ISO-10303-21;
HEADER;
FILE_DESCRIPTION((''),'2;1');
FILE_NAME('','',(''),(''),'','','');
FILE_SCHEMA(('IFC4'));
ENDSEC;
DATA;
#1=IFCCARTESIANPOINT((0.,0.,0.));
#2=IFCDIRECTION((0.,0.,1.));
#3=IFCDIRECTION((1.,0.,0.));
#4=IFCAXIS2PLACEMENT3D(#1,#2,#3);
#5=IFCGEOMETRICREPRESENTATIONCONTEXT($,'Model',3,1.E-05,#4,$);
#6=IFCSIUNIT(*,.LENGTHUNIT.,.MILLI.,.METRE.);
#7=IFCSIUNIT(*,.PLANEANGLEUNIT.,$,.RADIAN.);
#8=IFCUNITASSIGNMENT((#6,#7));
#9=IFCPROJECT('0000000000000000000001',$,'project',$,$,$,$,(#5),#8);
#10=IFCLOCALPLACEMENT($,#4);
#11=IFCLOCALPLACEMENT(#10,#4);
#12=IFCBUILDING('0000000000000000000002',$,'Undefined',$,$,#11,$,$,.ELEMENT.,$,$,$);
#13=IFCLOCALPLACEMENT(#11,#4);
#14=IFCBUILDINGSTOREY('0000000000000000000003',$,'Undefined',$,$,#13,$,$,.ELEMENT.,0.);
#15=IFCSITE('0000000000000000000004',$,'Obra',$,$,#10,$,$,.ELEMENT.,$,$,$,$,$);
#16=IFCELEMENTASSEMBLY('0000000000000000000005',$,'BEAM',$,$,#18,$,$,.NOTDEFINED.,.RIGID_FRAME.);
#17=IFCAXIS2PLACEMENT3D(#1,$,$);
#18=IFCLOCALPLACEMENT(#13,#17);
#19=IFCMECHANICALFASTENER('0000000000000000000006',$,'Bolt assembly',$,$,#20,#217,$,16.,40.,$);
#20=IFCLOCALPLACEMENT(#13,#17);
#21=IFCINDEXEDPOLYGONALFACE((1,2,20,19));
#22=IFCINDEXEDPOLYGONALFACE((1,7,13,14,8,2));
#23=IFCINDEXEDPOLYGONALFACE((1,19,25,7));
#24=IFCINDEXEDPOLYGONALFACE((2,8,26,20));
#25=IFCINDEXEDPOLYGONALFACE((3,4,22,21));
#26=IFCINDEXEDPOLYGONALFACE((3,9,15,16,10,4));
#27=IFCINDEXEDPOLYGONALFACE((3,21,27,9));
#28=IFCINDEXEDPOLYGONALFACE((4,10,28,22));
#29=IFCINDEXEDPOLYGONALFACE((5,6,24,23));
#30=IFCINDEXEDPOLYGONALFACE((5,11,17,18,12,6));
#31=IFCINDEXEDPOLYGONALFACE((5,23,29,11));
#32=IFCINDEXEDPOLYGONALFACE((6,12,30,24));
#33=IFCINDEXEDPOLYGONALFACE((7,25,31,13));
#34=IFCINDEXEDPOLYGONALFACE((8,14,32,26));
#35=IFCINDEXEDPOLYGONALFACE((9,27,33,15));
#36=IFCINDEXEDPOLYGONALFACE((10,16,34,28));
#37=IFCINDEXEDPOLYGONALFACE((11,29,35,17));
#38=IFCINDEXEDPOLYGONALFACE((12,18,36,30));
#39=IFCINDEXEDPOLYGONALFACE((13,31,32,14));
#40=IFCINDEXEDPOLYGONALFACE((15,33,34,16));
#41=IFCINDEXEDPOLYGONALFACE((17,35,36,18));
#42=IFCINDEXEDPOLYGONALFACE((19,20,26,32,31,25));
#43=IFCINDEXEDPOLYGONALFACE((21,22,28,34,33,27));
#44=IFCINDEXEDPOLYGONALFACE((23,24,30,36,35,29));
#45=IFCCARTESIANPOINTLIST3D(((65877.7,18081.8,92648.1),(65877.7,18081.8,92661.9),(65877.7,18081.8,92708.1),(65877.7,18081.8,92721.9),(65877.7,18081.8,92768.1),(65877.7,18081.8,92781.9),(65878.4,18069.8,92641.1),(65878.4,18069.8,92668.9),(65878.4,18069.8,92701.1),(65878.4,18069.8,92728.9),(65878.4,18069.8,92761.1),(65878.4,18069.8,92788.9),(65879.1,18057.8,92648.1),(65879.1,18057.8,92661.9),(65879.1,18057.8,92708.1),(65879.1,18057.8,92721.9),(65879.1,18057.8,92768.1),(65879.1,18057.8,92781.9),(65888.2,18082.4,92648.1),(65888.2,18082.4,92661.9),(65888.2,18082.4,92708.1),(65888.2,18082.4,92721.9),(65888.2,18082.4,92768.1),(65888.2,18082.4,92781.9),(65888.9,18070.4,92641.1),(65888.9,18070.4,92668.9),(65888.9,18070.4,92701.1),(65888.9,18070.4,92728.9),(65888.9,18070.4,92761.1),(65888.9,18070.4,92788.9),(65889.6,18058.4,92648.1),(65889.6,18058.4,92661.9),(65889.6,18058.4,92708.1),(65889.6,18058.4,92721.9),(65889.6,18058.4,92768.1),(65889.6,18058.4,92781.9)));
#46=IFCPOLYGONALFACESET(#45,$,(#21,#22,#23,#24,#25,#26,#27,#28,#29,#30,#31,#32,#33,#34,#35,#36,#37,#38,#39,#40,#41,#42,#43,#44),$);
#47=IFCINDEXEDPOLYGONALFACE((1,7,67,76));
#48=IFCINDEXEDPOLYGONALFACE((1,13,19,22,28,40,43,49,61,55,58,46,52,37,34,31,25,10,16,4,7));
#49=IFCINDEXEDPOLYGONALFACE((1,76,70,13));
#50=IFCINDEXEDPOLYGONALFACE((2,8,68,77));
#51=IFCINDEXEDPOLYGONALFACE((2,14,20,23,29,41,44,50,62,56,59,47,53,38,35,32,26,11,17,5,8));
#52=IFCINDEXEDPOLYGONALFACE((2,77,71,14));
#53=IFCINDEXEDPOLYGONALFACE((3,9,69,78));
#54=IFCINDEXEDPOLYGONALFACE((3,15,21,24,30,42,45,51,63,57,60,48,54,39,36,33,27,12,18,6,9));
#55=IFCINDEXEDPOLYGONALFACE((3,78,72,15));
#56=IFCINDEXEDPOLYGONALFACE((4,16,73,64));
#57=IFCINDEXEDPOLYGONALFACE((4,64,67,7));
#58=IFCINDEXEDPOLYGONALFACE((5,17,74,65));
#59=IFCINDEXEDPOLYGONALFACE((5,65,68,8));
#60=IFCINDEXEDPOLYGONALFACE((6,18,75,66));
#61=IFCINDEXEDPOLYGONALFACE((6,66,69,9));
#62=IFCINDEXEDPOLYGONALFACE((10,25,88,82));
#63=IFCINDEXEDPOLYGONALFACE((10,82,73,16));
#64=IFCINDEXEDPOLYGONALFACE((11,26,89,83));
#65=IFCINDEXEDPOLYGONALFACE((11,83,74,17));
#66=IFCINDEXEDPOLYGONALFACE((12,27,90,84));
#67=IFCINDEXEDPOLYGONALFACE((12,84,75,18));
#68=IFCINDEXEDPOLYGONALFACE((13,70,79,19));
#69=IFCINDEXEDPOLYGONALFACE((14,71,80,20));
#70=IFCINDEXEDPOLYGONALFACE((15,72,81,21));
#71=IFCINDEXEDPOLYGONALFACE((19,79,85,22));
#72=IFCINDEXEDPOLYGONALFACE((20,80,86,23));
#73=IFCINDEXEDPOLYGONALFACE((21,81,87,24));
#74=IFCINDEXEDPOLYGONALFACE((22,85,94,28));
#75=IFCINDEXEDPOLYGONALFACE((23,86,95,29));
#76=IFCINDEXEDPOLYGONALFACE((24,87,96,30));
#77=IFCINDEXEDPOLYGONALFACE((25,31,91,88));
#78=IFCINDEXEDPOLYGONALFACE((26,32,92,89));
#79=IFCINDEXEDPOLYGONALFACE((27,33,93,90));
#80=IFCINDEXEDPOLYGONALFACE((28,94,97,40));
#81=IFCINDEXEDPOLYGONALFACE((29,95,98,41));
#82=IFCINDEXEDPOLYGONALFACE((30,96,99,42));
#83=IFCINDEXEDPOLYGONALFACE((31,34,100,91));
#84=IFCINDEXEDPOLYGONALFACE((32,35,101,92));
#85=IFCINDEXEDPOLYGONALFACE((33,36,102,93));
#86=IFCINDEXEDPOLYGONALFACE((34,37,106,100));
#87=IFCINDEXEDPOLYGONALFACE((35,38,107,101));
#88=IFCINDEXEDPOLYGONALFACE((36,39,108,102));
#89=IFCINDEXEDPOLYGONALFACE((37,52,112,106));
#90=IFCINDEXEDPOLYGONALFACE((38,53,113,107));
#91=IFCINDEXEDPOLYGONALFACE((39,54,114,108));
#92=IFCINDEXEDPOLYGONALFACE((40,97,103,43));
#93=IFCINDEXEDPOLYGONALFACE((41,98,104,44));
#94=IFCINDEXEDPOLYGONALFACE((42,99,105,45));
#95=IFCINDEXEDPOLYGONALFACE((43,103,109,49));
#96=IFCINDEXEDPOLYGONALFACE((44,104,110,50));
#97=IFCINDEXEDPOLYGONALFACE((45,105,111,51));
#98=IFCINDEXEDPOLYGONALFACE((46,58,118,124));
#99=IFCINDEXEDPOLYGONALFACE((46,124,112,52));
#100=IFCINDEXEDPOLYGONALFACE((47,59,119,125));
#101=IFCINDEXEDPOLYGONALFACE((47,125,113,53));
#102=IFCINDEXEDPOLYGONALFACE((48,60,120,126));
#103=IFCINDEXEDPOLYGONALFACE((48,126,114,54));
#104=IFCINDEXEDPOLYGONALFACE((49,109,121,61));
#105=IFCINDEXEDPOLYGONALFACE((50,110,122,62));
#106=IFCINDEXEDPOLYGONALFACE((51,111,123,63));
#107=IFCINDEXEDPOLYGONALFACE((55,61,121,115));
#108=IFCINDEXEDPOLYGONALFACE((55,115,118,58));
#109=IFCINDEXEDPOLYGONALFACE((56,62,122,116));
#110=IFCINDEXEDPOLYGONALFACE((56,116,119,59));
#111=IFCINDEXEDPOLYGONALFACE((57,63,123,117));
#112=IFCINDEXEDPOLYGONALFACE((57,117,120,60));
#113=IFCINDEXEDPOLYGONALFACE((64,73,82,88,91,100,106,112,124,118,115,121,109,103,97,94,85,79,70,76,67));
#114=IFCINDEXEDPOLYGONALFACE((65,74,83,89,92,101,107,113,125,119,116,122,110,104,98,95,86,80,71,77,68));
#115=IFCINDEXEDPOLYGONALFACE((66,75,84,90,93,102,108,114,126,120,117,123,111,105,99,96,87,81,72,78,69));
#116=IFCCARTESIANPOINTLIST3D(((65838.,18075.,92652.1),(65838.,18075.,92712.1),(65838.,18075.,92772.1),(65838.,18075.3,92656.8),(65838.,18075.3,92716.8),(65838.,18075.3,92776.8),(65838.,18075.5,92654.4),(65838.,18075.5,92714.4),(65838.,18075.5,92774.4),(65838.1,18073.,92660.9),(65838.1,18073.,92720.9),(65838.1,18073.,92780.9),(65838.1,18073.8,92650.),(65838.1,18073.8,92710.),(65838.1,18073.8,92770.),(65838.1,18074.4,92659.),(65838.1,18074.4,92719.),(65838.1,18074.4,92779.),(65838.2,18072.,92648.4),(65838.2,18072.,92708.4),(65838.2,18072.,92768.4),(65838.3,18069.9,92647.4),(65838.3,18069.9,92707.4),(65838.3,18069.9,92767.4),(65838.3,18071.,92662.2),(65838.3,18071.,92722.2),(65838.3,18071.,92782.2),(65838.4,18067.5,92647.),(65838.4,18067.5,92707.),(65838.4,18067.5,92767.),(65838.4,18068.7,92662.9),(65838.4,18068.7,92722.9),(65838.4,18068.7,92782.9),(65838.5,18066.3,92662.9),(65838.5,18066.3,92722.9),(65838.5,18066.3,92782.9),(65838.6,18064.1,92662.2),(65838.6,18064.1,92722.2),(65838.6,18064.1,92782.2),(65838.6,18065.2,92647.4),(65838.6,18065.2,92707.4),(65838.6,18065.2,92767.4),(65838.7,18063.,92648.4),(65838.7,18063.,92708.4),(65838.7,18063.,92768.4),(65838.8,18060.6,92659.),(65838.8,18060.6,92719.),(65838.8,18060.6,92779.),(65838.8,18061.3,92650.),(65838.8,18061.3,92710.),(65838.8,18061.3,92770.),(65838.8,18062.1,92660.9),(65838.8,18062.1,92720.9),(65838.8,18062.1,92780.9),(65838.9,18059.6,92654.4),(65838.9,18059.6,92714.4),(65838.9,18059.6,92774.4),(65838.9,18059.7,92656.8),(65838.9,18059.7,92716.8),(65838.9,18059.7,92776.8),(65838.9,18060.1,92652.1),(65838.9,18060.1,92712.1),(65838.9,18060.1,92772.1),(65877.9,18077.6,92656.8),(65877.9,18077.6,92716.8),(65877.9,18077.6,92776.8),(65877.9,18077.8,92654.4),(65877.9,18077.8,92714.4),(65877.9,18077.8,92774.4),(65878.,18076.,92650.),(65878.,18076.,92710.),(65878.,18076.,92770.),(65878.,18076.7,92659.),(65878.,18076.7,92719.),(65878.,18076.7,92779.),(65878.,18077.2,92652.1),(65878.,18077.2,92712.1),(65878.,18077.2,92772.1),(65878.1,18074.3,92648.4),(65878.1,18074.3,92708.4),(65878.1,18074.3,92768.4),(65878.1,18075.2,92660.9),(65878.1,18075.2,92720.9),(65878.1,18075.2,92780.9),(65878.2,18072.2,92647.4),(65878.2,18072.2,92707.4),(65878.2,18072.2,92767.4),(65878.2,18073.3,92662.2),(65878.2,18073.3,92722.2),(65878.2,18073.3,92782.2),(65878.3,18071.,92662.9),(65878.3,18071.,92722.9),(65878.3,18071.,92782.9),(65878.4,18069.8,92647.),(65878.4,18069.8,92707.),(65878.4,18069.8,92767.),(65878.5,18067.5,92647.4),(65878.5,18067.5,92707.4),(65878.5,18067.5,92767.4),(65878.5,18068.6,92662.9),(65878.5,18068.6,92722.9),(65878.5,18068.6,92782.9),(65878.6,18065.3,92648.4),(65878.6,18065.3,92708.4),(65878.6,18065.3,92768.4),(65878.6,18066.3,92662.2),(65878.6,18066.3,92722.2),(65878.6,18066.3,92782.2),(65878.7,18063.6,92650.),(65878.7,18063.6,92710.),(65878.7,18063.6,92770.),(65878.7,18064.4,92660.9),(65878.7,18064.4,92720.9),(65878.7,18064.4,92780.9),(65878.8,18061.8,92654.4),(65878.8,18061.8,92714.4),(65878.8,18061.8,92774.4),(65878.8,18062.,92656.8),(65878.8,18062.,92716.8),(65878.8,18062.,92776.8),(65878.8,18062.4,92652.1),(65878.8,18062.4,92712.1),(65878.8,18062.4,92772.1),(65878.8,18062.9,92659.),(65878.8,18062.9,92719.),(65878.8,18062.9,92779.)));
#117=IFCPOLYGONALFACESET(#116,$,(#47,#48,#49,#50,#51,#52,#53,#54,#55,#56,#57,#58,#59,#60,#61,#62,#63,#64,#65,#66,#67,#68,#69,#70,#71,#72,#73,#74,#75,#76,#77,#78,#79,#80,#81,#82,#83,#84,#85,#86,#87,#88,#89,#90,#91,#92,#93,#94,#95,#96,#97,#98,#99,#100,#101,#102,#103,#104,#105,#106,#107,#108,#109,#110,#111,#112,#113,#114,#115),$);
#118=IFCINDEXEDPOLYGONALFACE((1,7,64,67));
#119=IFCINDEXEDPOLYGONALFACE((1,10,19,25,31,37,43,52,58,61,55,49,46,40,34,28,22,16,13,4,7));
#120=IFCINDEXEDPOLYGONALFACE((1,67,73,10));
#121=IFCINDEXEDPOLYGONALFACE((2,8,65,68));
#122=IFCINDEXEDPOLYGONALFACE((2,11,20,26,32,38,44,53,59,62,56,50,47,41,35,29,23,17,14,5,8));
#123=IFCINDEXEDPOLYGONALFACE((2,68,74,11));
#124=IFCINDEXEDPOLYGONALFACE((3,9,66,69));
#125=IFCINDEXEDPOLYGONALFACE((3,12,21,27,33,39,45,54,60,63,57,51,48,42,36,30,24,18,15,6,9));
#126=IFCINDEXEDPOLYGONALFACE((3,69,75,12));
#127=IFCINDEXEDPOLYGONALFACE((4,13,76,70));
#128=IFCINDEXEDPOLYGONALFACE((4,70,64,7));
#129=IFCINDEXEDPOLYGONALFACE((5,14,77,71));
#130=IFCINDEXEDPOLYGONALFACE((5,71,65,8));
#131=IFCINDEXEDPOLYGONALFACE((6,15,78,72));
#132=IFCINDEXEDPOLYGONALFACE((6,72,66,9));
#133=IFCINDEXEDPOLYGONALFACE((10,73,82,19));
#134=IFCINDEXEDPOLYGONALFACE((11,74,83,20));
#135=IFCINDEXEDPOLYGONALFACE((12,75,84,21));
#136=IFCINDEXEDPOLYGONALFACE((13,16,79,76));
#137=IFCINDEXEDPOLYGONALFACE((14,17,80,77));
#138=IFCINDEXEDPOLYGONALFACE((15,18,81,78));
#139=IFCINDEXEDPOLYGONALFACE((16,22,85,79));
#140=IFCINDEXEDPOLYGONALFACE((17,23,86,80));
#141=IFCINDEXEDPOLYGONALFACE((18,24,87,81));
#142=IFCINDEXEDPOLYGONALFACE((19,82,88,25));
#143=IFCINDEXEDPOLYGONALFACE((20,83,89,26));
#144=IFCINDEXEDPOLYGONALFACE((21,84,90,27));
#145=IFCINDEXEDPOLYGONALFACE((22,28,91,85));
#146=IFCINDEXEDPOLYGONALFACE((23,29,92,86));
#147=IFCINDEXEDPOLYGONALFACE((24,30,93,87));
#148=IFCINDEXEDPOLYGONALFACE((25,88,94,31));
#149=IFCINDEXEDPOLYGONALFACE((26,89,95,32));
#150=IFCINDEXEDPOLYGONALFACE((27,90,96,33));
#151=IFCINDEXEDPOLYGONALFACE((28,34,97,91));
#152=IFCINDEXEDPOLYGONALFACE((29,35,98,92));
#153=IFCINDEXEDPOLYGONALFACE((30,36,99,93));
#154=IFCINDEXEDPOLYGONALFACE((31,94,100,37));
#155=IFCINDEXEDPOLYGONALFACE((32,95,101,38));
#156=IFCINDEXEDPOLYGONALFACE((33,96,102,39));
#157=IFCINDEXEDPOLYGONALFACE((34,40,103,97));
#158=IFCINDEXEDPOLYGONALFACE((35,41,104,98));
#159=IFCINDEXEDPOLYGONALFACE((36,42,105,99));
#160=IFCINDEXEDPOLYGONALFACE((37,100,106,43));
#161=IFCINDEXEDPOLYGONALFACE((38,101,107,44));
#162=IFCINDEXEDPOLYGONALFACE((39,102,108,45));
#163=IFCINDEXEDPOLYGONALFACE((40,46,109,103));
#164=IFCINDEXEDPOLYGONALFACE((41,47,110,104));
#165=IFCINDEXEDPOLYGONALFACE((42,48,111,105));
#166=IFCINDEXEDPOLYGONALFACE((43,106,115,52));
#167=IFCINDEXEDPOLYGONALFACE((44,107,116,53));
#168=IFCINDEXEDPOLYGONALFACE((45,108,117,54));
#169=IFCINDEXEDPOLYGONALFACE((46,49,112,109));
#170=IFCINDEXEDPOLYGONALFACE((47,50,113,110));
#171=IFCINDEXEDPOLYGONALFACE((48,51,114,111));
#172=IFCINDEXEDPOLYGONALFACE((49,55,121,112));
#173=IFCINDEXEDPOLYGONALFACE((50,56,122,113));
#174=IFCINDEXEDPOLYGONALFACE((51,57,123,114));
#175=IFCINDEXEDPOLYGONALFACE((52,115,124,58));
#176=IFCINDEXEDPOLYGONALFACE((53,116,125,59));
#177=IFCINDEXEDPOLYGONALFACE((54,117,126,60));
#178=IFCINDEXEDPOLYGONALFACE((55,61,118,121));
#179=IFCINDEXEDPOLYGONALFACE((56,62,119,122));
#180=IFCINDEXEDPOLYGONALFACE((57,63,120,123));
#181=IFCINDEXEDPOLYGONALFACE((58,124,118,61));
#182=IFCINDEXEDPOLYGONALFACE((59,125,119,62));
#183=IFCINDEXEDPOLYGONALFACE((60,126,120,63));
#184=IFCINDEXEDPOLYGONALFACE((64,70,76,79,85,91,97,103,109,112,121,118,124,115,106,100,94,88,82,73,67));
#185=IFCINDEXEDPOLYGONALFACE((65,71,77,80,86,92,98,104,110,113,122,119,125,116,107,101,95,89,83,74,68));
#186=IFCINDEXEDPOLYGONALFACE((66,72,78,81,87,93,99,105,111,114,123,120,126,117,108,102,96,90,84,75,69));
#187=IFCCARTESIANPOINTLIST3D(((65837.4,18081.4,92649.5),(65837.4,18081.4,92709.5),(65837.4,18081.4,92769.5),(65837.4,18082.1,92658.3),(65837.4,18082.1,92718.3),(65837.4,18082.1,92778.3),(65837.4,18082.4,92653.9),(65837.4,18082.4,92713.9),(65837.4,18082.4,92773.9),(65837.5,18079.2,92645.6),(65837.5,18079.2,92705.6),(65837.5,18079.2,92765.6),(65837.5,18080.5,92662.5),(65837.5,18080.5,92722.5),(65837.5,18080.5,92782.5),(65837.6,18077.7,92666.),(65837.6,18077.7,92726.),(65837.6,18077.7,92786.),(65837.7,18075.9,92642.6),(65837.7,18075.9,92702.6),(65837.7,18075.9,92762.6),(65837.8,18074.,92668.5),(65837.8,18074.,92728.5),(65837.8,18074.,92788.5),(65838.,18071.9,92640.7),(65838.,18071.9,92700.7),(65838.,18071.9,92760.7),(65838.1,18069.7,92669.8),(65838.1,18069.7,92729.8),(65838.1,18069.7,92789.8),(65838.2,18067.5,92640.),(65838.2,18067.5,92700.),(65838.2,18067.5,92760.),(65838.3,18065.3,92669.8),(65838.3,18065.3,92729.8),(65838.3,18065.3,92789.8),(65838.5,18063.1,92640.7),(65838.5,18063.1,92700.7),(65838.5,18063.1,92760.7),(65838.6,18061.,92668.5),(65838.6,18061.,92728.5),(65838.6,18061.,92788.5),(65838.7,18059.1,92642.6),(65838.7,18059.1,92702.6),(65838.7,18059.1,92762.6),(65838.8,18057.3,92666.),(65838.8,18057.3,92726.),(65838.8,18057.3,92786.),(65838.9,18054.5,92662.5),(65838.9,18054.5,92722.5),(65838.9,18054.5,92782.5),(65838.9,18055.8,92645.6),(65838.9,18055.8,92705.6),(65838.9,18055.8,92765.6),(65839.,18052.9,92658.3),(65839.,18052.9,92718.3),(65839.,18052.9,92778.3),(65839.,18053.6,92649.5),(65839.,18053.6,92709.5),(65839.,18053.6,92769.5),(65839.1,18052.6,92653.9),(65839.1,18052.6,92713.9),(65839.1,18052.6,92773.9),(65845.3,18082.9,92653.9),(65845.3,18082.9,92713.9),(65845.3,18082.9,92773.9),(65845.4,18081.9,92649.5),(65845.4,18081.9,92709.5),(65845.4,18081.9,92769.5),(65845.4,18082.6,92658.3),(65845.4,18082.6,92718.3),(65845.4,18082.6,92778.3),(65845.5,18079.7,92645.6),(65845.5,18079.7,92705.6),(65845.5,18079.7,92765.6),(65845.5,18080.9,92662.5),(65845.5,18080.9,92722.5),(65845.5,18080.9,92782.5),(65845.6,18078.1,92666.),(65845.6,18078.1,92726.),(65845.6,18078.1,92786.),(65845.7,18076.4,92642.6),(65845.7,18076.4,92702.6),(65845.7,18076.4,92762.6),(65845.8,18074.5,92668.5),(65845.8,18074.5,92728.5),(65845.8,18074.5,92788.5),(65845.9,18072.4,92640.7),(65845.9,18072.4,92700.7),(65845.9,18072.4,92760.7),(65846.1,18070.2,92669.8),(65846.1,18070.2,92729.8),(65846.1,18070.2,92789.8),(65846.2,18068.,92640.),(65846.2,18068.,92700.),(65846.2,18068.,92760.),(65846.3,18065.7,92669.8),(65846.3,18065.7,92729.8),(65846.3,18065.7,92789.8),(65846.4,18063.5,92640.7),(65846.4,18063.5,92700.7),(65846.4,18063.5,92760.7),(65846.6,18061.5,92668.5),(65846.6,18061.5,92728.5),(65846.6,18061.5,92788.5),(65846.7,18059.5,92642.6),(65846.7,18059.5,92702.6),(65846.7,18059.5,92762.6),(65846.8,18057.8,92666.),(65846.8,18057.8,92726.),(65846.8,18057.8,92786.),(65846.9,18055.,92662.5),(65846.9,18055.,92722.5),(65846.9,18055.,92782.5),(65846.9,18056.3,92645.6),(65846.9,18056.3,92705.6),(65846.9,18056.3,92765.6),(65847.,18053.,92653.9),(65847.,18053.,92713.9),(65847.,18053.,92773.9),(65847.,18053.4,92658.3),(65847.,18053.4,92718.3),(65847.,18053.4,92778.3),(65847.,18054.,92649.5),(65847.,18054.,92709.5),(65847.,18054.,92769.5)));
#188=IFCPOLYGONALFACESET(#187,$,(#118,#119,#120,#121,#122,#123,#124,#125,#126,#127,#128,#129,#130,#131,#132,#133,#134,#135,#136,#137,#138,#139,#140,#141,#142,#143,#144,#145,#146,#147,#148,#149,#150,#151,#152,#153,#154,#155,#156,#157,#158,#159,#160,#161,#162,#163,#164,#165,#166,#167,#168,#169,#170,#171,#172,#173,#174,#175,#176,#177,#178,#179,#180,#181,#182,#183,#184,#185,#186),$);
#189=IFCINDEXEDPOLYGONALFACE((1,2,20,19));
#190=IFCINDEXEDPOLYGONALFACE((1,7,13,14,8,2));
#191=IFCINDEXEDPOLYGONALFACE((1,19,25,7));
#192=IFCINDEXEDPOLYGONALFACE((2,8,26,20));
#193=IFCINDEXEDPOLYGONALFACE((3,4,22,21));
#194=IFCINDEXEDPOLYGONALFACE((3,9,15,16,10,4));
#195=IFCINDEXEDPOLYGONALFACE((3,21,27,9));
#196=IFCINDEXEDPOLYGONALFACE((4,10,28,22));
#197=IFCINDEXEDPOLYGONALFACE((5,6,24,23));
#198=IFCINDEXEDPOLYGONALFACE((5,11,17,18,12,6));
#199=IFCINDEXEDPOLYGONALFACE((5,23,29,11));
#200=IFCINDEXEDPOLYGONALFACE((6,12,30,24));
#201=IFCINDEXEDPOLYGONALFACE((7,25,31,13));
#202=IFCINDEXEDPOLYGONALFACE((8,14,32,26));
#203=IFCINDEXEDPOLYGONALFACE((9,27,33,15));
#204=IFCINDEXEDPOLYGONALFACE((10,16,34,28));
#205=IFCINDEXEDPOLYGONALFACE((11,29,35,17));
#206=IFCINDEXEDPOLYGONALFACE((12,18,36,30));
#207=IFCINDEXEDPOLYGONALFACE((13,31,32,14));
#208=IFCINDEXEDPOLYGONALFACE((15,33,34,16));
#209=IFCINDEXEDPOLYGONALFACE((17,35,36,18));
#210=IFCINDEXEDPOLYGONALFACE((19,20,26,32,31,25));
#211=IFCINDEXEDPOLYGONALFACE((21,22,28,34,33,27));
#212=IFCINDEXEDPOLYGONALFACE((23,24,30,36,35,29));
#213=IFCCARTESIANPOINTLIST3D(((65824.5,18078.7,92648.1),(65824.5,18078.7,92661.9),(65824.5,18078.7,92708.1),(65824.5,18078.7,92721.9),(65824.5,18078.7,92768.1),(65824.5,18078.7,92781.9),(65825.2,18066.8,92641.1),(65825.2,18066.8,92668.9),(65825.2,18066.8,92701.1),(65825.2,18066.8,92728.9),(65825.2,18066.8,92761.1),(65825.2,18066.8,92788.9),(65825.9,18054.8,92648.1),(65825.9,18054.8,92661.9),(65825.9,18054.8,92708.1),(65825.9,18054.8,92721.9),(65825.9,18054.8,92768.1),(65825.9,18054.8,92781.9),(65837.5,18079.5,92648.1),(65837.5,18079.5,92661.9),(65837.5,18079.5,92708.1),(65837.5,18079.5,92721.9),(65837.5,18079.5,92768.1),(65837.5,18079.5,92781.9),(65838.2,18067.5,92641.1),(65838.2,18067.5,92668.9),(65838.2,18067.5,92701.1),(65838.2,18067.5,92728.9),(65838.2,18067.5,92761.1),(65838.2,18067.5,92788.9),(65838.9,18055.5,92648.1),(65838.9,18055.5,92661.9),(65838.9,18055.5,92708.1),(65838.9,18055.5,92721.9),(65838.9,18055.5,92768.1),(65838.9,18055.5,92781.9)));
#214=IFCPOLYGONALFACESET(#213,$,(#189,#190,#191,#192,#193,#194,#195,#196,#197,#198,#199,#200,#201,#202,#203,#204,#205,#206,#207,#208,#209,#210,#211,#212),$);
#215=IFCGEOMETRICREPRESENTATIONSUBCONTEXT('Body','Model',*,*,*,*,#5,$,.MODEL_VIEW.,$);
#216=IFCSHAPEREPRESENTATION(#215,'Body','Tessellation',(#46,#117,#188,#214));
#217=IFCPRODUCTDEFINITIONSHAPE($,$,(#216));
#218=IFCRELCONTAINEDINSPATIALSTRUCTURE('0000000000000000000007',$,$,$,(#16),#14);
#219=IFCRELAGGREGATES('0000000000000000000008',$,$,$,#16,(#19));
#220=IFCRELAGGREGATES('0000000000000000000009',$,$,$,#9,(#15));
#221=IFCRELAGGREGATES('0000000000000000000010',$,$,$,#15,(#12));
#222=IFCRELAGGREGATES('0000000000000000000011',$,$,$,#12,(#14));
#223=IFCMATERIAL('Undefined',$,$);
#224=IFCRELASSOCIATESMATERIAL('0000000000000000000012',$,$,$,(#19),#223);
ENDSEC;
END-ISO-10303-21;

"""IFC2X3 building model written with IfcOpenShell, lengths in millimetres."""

from ifc_helpers import new_model, si_unit, frame, origin_with_axes, origin_2d_with_axis, place, context, subcontext, project, spatial, polyline, circle, outline, extrude, source, transform, mapped, material, element, aggregate, save


model = new_model("IFC2X3")

# Units and contexts
model_context = context("Model", 3, precision=1e-05, world=origin_with_axes())
body_context = subcontext(model_context, "Body", "Model", "MODEL_VIEW")
ifc_project = project(units=[si_unit("LENGTHUNIT", "METRE", prefix="MILLI"), si_unit("PLANEANGLEUNIT", "RADIAN")], contexts=[model_context])

# Site, building, storey
site_placement = place(None, origin_with_axes())
site = spatial("IfcSite", under=ifc_project, at=site_placement, Name="Obra", CompositionType="ELEMENT")
building_placement = place(site_placement, origin_with_axes())
building = spatial("IfcBuilding", under=site, at=building_placement, Name="Undefined", CompositionType="ELEMENT")
storey_placement = place(building_placement, origin_with_axes())
storey = spatial("IfcBuildingStorey", under=building, at=storey_placement, Name="Undefined", CompositionType="ELEMENT", Elevation=0.0)

# Shared definitions
ifc_material_1 = material(Name="Undefined")

# Element assembly, mechanical fastener
assembly_1_placement = place(storey_placement, origin_with_axes())
assembly_1 = element("IfcElementAssembly", 1, at=assembly_1_placement, inside=storey, Name="BEAM", AssemblyPlace="NOTDEFINED", PredefinedType="RIGID_FRAME")
shared_shape_1 = source(origin_with_axes(), body_context, "Body", "SweptSolid", [
    extrude(outline(polyline([(13.9, 0.0), (6.9, 12.0), (-6.9, 12.0), (-13.9, 0.0), (-6.9, -12.0), (6.9, -12.0), (13.9, 0.0)])), frame((0.0, -45.9, 0.0), z_axis=(0.0, 1.0, 0.0), x_axis=(1.0, 0.0, 0.0)), (0.0, 0.0, 1.0), 10.6),
    extrude(circle(Radius=8.0, at=origin_2d_with_axis()), frame((0.0, -35.3, 0.0), z_axis=(0.0, 1.0, 0.0), x_axis=(1.0, 0.0, 0.0)), (0.0, 0.0, 1.0), 40.0),
    extrude(circle(Radius=15.0, at=origin_2d_with_axis()), frame((0.0, -3.1, 0.0), z_axis=(0.0, 1.0, 0.0), x_axis=(1.0, 0.0, 0.0)), (0.0, 0.0, 1.0), 8.0),
    extrude(outline(polyline([(13.9, 0.0), (6.9, 12.0), (-6.9, 12.0), (-13.9, 0.0), (-6.9, -12.0), (6.9, -12.0), (13.9, 0.0)])), frame((0.0, 4.9, 0.0), z_axis=(0.0, 1.0, 0.0), x_axis=(1.0, 0.0, 0.0)), (0.0, 0.0, 1.0), 13.0),
])
mechanical_fastener_1_placement = place(assembly_1_placement, frame((65846.0, 18017.9, 92835.0), z_axis=(-0.057107, 0.998368, 0.0), x_axis=(0.0, 0.0, -1.0)))
mechanical_fastener_1 = element("IfcMechanicalFastener", 2, at=mechanical_fastener_1_placement, material=ifc_material_1, Name="Bolt assembly", NominalDiameter=16.0, NominalLength=40.0, context=body_context, shape_type="MappedRepresentation", body=[
    mapped(shared_shape_1, transform((60.0, 0.0, 50.0))),
    mapped(shared_shape_1, transform((120.0, 0.0, 50.0))),
    mapped(shared_shape_1, transform((180.0, 0.0, 50.0))),
])
aggregate(assembly_1, [mechanical_fastener_1])

save(model, "model.ifc")
